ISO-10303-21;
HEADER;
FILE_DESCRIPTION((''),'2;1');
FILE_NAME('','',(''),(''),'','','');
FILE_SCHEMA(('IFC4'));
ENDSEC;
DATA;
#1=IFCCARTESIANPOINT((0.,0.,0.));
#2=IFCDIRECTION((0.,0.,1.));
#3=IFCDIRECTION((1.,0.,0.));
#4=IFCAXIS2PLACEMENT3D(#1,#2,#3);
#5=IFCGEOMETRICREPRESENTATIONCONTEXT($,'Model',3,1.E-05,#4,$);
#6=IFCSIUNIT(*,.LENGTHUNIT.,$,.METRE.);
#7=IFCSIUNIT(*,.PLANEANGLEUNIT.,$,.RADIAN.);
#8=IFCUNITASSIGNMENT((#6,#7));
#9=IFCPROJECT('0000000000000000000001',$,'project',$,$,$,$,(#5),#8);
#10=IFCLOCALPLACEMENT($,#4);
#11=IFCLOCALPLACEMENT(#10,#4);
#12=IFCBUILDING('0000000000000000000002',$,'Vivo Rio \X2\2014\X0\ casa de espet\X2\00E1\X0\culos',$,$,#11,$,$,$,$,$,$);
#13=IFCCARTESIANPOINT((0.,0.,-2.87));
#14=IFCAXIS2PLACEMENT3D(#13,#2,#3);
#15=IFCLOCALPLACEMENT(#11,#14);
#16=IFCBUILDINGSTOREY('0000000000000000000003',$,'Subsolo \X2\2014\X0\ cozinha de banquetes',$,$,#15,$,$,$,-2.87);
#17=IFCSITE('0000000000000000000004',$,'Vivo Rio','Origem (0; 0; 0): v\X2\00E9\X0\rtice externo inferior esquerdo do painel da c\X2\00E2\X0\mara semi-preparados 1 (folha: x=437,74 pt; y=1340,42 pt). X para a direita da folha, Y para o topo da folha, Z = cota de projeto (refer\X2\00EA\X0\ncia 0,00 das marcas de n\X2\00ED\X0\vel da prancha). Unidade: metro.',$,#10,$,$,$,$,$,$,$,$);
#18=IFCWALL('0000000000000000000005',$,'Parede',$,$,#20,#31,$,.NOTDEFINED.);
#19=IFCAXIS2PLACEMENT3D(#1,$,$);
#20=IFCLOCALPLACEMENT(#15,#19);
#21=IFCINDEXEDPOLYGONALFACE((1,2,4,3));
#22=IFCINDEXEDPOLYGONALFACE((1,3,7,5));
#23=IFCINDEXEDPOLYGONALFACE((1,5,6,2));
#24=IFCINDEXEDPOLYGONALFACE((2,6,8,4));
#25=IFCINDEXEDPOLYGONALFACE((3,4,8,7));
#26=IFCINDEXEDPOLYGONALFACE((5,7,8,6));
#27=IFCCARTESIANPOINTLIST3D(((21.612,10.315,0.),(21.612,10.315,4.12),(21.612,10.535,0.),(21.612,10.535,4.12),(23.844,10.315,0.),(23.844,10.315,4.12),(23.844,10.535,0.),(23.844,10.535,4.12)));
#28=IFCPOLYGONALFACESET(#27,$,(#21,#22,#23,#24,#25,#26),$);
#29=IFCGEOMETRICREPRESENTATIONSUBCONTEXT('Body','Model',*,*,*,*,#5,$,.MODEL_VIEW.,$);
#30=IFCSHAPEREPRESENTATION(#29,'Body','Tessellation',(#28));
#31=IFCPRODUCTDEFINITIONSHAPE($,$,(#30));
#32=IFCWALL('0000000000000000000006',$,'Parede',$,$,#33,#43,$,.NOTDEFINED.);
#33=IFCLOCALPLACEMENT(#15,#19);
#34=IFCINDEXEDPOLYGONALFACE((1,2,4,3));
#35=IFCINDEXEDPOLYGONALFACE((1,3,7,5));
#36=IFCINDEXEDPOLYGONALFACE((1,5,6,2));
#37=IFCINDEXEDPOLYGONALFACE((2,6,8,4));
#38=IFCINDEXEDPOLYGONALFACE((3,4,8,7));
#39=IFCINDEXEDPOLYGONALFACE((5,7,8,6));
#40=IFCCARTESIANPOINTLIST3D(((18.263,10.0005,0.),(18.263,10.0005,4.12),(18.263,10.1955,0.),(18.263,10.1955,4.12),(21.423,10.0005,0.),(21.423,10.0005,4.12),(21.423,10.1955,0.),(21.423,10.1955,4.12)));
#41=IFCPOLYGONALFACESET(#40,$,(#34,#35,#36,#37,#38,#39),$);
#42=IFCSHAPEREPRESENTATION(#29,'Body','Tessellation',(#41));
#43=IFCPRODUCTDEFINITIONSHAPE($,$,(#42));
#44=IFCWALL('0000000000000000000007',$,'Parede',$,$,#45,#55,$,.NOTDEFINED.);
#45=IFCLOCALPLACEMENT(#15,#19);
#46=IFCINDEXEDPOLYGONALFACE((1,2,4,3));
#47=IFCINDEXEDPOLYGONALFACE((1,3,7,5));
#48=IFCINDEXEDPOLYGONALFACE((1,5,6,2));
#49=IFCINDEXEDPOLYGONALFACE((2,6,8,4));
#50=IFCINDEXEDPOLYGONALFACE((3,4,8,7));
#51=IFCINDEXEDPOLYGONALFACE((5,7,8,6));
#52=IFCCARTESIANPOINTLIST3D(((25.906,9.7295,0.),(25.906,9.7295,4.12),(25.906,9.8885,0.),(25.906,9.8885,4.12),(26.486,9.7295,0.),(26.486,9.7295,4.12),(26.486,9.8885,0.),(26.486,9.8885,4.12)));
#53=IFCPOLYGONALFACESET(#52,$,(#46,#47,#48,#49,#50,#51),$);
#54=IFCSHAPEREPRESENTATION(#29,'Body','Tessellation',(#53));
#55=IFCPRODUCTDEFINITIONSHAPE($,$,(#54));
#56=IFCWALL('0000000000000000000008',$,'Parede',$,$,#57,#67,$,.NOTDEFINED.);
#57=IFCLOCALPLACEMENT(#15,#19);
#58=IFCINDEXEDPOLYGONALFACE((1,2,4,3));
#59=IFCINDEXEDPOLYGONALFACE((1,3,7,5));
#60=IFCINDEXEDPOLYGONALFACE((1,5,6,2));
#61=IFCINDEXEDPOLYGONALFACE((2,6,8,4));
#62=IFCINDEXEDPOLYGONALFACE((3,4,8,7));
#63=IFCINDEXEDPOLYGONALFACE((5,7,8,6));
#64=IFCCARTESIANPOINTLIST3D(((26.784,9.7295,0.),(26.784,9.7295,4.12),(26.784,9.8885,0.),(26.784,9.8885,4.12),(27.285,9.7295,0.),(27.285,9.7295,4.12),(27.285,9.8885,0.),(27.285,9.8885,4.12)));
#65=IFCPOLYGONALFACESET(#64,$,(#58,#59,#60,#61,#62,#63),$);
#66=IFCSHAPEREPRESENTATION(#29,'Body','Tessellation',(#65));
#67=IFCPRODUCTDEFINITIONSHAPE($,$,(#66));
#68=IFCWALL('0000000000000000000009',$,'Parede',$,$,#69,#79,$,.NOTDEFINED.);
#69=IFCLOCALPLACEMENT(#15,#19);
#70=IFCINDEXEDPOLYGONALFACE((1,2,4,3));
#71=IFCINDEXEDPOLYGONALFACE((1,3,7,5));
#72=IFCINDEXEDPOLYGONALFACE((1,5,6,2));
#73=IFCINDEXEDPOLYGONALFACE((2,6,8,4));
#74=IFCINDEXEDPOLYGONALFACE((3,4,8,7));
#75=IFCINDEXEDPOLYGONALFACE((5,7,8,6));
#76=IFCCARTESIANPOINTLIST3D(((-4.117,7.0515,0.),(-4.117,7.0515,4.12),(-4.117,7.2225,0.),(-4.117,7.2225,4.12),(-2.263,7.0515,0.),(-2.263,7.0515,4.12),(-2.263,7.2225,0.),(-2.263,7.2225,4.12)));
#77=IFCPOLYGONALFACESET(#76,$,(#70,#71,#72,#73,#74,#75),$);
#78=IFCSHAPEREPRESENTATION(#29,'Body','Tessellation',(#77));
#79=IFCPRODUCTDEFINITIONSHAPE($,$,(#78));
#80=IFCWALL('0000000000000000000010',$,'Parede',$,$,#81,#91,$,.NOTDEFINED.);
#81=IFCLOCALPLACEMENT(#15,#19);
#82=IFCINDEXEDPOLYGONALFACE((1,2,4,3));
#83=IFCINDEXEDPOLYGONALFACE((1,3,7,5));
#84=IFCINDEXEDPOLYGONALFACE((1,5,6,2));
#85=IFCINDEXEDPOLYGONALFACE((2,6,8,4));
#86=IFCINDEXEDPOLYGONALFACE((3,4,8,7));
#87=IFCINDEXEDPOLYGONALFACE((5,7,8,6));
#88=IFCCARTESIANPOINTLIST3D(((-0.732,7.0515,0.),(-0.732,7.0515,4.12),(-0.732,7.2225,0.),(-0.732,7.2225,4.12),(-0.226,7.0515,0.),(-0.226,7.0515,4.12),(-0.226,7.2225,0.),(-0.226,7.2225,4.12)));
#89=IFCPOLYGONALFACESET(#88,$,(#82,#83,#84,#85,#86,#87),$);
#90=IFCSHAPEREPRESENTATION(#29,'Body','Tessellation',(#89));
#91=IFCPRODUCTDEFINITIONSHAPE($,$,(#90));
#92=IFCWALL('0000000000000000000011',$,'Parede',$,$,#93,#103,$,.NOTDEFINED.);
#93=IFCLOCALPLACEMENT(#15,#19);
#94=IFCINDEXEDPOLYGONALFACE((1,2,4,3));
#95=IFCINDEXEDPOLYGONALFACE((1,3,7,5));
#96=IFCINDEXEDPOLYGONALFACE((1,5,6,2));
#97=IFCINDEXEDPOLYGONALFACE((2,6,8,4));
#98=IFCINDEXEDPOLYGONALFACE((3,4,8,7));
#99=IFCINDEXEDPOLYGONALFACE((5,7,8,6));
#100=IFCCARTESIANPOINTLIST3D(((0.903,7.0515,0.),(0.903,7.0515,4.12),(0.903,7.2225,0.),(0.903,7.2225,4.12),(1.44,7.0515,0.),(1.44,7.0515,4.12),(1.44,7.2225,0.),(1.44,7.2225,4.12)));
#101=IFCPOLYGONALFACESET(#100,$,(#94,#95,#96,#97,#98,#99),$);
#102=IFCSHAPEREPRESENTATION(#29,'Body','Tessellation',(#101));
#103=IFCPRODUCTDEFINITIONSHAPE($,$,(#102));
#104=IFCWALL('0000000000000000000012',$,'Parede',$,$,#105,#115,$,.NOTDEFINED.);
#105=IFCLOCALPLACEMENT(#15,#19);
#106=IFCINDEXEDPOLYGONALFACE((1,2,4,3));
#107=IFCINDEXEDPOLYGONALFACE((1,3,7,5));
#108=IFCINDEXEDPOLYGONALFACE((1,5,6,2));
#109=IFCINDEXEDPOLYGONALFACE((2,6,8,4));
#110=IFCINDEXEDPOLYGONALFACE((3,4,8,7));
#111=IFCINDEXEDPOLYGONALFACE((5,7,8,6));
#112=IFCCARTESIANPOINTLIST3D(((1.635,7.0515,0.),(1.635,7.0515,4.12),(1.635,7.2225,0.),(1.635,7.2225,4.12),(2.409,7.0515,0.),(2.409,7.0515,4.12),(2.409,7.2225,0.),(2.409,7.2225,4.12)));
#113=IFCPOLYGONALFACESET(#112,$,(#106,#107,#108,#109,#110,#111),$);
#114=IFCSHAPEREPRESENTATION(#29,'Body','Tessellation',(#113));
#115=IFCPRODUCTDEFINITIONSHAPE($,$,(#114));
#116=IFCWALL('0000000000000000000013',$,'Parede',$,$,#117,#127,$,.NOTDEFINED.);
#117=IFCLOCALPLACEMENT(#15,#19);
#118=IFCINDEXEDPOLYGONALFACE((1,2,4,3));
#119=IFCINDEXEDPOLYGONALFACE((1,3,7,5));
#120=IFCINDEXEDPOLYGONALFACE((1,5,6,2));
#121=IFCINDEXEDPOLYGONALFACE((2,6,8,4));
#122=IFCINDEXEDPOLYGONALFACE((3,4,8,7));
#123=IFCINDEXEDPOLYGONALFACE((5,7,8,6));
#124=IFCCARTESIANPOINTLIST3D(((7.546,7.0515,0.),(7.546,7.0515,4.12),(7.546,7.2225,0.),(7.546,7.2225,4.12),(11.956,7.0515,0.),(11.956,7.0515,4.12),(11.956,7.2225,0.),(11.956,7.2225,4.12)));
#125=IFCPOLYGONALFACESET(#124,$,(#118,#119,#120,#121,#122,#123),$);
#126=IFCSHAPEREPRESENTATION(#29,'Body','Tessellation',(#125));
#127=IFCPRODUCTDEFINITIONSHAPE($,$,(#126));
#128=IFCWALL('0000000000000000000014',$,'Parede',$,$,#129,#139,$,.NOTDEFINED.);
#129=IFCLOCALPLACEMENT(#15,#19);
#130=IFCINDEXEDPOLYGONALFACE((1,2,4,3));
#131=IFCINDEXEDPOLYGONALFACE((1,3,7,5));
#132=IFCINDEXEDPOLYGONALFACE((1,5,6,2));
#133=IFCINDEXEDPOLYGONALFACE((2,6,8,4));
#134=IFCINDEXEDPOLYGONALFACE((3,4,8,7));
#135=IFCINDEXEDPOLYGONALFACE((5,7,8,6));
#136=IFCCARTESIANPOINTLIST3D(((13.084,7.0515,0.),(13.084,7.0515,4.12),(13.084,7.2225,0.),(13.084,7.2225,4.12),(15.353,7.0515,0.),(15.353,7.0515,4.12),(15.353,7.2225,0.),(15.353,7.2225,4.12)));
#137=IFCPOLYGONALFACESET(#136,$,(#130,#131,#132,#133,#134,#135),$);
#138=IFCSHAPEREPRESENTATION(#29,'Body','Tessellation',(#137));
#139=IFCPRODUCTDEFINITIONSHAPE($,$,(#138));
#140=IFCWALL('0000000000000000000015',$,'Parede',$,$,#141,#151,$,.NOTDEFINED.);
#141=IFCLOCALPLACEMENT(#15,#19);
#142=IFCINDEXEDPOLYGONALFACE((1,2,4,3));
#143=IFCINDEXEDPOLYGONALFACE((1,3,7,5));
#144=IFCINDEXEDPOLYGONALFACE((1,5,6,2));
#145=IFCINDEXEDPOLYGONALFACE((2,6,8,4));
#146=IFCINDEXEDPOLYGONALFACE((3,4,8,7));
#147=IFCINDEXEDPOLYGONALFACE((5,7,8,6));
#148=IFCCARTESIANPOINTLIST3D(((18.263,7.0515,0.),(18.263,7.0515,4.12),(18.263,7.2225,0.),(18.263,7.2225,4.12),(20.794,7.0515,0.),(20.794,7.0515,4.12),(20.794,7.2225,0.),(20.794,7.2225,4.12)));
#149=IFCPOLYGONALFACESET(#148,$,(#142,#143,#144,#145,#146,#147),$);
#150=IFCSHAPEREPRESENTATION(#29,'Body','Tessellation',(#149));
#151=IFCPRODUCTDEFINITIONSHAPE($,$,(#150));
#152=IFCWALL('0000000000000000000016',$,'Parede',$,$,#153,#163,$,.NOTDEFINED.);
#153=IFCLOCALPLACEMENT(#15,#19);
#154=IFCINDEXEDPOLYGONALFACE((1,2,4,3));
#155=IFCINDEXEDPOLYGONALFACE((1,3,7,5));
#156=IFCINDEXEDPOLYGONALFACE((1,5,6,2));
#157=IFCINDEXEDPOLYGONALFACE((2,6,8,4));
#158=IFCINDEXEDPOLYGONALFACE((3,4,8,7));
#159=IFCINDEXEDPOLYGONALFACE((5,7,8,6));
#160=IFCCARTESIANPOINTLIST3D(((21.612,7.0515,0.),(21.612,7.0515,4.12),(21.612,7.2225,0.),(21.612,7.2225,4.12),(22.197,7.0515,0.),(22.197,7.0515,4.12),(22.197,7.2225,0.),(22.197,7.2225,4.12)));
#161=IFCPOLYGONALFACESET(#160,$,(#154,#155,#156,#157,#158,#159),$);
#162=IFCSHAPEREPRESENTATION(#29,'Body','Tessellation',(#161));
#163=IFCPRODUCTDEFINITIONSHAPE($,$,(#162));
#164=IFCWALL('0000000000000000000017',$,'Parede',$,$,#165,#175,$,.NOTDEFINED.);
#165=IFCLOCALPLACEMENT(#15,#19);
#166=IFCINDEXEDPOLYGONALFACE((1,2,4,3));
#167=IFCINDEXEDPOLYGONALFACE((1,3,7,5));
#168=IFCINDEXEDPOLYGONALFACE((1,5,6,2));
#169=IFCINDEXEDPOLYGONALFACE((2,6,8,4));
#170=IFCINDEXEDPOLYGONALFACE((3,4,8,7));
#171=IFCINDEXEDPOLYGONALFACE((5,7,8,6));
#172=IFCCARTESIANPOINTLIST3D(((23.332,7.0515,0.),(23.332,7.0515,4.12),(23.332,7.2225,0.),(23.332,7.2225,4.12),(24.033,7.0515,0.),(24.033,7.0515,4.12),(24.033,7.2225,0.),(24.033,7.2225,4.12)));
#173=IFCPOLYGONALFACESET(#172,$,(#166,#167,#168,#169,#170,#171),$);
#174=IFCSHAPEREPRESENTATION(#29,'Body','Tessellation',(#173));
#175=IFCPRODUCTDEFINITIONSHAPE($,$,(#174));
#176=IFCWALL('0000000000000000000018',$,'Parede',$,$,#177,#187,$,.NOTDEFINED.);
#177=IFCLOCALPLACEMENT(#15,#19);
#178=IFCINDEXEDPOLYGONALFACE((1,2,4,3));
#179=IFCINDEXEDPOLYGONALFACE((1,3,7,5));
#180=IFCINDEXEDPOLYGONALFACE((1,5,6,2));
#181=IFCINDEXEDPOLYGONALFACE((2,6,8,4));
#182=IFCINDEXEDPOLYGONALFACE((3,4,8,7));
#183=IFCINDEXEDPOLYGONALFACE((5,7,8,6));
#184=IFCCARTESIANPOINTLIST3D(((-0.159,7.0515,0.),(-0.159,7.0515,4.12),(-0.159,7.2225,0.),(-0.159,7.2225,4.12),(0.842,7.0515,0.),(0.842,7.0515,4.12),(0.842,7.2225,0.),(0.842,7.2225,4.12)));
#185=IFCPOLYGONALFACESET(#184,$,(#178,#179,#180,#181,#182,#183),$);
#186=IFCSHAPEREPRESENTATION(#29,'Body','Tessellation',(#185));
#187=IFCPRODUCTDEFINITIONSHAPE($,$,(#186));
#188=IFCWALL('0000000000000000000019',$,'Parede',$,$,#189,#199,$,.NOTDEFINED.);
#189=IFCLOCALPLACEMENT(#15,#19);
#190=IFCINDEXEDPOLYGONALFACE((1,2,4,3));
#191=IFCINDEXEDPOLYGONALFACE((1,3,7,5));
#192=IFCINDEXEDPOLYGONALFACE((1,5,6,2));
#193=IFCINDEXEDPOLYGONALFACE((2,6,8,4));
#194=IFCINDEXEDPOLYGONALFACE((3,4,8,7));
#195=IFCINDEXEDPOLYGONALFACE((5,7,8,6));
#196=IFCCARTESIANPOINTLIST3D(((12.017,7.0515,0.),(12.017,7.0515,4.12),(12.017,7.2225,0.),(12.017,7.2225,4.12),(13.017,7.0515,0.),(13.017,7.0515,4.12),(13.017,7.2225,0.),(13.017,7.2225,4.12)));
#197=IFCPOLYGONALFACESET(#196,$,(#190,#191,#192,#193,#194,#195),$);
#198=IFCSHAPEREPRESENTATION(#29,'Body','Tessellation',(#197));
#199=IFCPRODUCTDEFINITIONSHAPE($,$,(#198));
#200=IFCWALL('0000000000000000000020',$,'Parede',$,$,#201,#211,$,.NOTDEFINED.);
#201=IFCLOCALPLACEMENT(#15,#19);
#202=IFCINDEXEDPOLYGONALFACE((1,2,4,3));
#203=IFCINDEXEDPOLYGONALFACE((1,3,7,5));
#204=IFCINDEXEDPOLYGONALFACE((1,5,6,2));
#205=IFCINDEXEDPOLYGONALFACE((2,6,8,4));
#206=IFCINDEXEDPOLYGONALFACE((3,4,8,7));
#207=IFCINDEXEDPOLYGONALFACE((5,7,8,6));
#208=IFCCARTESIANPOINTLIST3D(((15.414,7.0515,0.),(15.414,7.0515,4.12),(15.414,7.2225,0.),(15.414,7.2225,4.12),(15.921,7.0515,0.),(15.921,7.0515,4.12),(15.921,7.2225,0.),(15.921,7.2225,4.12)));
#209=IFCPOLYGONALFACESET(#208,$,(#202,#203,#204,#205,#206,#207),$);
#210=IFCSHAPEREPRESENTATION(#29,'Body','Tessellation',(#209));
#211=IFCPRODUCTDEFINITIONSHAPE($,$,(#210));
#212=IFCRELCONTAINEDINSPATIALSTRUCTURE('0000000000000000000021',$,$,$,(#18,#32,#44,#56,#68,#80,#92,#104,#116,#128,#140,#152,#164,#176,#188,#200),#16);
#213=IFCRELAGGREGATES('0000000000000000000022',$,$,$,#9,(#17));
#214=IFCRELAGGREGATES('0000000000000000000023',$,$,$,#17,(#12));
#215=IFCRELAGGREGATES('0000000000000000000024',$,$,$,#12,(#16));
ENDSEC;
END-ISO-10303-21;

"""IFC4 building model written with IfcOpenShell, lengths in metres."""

from ifc_helpers import new_model, si_unit, frame, origin_with_axes, origin_2d, place, context, subcontext, project, spatial, rectangle, extrude, element, save


model = new_model("IFC4")

# Units and contexts
model_context = context("Model", 3, precision=1e-05, world=origin_with_axes())
body_context = subcontext(model_context, "Body", "Model", "MODEL_VIEW")
ifc_project = project(units=[si_unit("LENGTHUNIT", "METRE"), si_unit("PLANEANGLEUNIT", "RADIAN")], contexts=[model_context])

# Site, building, storey
site_placement = place(None, origin_with_axes())
site = spatial("IfcSite", under=ifc_project, at=site_placement, Name="Vivo Rio", Description="Origem (0; 0; 0): vértice externo inferior esquerdo do painel da câmara semi-preparados 1 (folha: x=437,74 pt; y=1340,42 pt). X para a direita da folha, Y para o topo da folha, Z = cota de projeto (referência 0,00 das marcas de nível da prancha). Unidade: metro.")
building_placement = place(site_placement, origin_with_axes())
building = spatial("IfcBuilding", under=site, at=building_placement, Name="Vivo Rio — casa de espetáculos")
storey_placement = place(building_placement, frame((0.0, 0.0, -2.87), z_axis=(0.0, 0.0, 1.0), x_axis=(1.0, 0.0, 0.0)))
storey = spatial("IfcBuildingStorey", under=building, at=storey_placement, Name="Subsolo — cozinha de banquetes", Elevation=-2.87)

# Walls
wall_1_placement = place(storey_placement, origin_with_axes())
element("IfcWall", 1, at=wall_1_placement, inside=storey, Name="Parede", PredefinedType="NOTDEFINED", context=body_context, shape_type="SweptSolid", body=[
    extrude(rectangle(XDim=2.232, YDim=0.22, at=origin_2d()), frame((22.728, 10.425, 0.0), z_axis=(0.0, 0.0, 1.0), x_axis=(1.0, 0.0, 0.0)), (0.0, 0.0, 1.0), 4.12),
])
wall_2_placement = place(storey_placement, origin_with_axes())
element("IfcWall", 2, at=wall_2_placement, inside=storey, Name="Parede", PredefinedType="NOTDEFINED", context=body_context, shape_type="SweptSolid", body=[
    extrude(rectangle(XDim=3.16, YDim=0.195, at=origin_2d()), frame((19.843, 10.098, 0.0), z_axis=(0.0, 0.0, 1.0), x_axis=(1.0, 0.0, 0.0)), (0.0, 0.0, 1.0), 4.12),
])
wall_3_placement = place(storey_placement, origin_with_axes())
element("IfcWall", 3, at=wall_3_placement, inside=storey, Name="Parede", PredefinedType="NOTDEFINED", context=body_context, shape_type="SweptSolid", body=[
    extrude(rectangle(XDim=0.58, YDim=0.159, at=origin_2d()), frame((26.196, 9.809, 0.0), z_axis=(0.0, 0.0, 1.0), x_axis=(1.0, 0.0, 0.0)), (0.0, 0.0, 1.0), 4.12),
])
wall_4_placement = place(storey_placement, origin_with_axes())
element("IfcWall", 4, at=wall_4_placement, inside=storey, Name="Parede", PredefinedType="NOTDEFINED", context=body_context, shape_type="SweptSolid", body=[
    extrude(rectangle(XDim=0.501, YDim=0.159, at=origin_2d()), frame((27.0345, 9.809, 0.0), z_axis=(0.0, 0.0, 1.0), x_axis=(1.0, 0.0, 0.0)), (0.0, 0.0, 1.0), 4.12),
])
wall_5_placement = place(storey_placement, origin_with_axes())
element("IfcWall", 5, at=wall_5_placement, inside=storey, Name="Parede", PredefinedType="NOTDEFINED", context=body_context, shape_type="SweptSolid", body=[
    extrude(rectangle(XDim=1.854, YDim=0.171, at=origin_2d()), frame((-3.19, 7.137, 0.0), z_axis=(0.0, 0.0, 1.0), x_axis=(1.0, 0.0, 0.0)), (0.0, 0.0, 1.0), 4.12),
])
wall_6_placement = place(storey_placement, origin_with_axes())
element("IfcWall", 6, at=wall_6_placement, inside=storey, Name="Parede", PredefinedType="NOTDEFINED", context=body_context, shape_type="SweptSolid", body=[
    extrude(rectangle(XDim=0.506, YDim=0.171, at=origin_2d()), frame((-0.479, 7.137, 0.0), z_axis=(0.0, 0.0, 1.0), x_axis=(1.0, 0.0, 0.0)), (0.0, 0.0, 1.0), 4.12),
])
wall_7_placement = place(storey_placement, origin_with_axes())
element("IfcWall", 7, at=wall_7_placement, inside=storey, Name="Parede", PredefinedType="NOTDEFINED", context=body_context, shape_type="SweptSolid", body=[
    extrude(rectangle(XDim=0.537, YDim=0.171, at=origin_2d()), frame((1.1715, 7.137, 0.0), z_axis=(0.0, 0.0, 1.0), x_axis=(1.0, 0.0, 0.0)), (0.0, 0.0, 1.0), 4.12),
])
wall_8_placement = place(storey_placement, origin_with_axes())
element("IfcWall", 8, at=wall_8_placement, inside=storey, Name="Parede", PredefinedType="NOTDEFINED", context=body_context, shape_type="SweptSolid", body=[
    extrude(rectangle(XDim=0.774, YDim=0.171, at=origin_2d()), frame((2.022, 7.137, 0.0), z_axis=(0.0, 0.0, 1.0), x_axis=(1.0, 0.0, 0.0)), (0.0, 0.0, 1.0), 4.12),
])
wall_9_placement = place(storey_placement, origin_with_axes())
element("IfcWall", 9, at=wall_9_placement, inside=storey, Name="Parede", PredefinedType="NOTDEFINED", context=body_context, shape_type="SweptSolid", body=[
    extrude(rectangle(XDim=4.41, YDim=0.171, at=origin_2d()), frame((9.751, 7.137, 0.0), z_axis=(0.0, 0.0, 1.0), x_axis=(1.0, 0.0, 0.0)), (0.0, 0.0, 1.0), 4.12),
])
wall_10_placement = place(storey_placement, origin_with_axes())
element("IfcWall", 10, at=wall_10_placement, inside=storey, Name="Parede", PredefinedType="NOTDEFINED", context=body_context, shape_type="SweptSolid", body=[
    extrude(rectangle(XDim=2.269, YDim=0.171, at=origin_2d()), frame((14.2185, 7.137, 0.0), z_axis=(0.0, 0.0, 1.0), x_axis=(1.0, 0.0, 0.0)), (0.0, 0.0, 1.0), 4.12),
])
wall_11_placement = place(storey_placement, origin_with_axes())
element("IfcWall", 11, at=wall_11_placement, inside=storey, Name="Parede", PredefinedType="NOTDEFINED", context=body_context, shape_type="SweptSolid", body=[
    extrude(rectangle(XDim=2.531, YDim=0.171, at=origin_2d()), frame((19.5285, 7.137, 0.0), z_axis=(0.0, 0.0, 1.0), x_axis=(1.0, 0.0, 0.0)), (0.0, 0.0, 1.0), 4.12),
])
wall_12_placement = place(storey_placement, origin_with_axes())
element("IfcWall", 12, at=wall_12_placement, inside=storey, Name="Parede", PredefinedType="NOTDEFINED", context=body_context, shape_type="SweptSolid", body=[
    extrude(rectangle(XDim=0.585, YDim=0.171, at=origin_2d()), frame((21.9045, 7.137, 0.0), z_axis=(0.0, 0.0, 1.0), x_axis=(1.0, 0.0, 0.0)), (0.0, 0.0, 1.0), 4.12),
])
wall_13_placement = place(storey_placement, origin_with_axes())
element("IfcWall", 13, at=wall_13_placement, inside=storey, Name="Parede", PredefinedType="NOTDEFINED", context=body_context, shape_type="SweptSolid", body=[
    extrude(rectangle(XDim=0.701, YDim=0.171, at=origin_2d()), frame((23.6825, 7.137, 0.0), z_axis=(0.0, 0.0, 1.0), x_axis=(1.0, 0.0, 0.0)), (0.0, 0.0, 1.0), 4.12),
])
wall_14_placement = place(storey_placement, origin_with_axes())
element("IfcWall", 14, at=wall_14_placement, inside=storey, Name="Parede", PredefinedType="NOTDEFINED", context=body_context, shape_type="SweptSolid", body=[
    extrude(rectangle(XDim=1.001, YDim=0.171, at=origin_2d()), frame((0.3415, 7.137, 0.0), z_axis=(0.0, 0.0, 1.0), x_axis=(1.0, 0.0, 0.0)), (0.0, 0.0, 1.0), 4.12),
])
wall_15_placement = place(storey_placement, origin_with_axes())
element("IfcWall", 15, at=wall_15_placement, inside=storey, Name="Parede", PredefinedType="NOTDEFINED", context=body_context, shape_type="SweptSolid", body=[
    extrude(rectangle(XDim=1.0, YDim=0.171, at=origin_2d()), frame((12.517, 7.137, 0.0), z_axis=(0.0, 0.0, 1.0), x_axis=(1.0, 0.0, 0.0)), (0.0, 0.0, 1.0), 4.12),
])
wall_16_placement = place(storey_placement, origin_with_axes())
element("IfcWall", 16, at=wall_16_placement, inside=storey, Name="Parede", PredefinedType="NOTDEFINED", context=body_context, shape_type="SweptSolid", body=[
    extrude(rectangle(XDim=0.507, YDim=0.171, at=origin_2d()), frame((15.6675, 7.137, 0.0), z_axis=(0.0, 0.0, 1.0), x_axis=(1.0, 0.0, 0.0)), (0.0, 0.0, 1.0), 4.12),
])

save(model, "model.ifc")
